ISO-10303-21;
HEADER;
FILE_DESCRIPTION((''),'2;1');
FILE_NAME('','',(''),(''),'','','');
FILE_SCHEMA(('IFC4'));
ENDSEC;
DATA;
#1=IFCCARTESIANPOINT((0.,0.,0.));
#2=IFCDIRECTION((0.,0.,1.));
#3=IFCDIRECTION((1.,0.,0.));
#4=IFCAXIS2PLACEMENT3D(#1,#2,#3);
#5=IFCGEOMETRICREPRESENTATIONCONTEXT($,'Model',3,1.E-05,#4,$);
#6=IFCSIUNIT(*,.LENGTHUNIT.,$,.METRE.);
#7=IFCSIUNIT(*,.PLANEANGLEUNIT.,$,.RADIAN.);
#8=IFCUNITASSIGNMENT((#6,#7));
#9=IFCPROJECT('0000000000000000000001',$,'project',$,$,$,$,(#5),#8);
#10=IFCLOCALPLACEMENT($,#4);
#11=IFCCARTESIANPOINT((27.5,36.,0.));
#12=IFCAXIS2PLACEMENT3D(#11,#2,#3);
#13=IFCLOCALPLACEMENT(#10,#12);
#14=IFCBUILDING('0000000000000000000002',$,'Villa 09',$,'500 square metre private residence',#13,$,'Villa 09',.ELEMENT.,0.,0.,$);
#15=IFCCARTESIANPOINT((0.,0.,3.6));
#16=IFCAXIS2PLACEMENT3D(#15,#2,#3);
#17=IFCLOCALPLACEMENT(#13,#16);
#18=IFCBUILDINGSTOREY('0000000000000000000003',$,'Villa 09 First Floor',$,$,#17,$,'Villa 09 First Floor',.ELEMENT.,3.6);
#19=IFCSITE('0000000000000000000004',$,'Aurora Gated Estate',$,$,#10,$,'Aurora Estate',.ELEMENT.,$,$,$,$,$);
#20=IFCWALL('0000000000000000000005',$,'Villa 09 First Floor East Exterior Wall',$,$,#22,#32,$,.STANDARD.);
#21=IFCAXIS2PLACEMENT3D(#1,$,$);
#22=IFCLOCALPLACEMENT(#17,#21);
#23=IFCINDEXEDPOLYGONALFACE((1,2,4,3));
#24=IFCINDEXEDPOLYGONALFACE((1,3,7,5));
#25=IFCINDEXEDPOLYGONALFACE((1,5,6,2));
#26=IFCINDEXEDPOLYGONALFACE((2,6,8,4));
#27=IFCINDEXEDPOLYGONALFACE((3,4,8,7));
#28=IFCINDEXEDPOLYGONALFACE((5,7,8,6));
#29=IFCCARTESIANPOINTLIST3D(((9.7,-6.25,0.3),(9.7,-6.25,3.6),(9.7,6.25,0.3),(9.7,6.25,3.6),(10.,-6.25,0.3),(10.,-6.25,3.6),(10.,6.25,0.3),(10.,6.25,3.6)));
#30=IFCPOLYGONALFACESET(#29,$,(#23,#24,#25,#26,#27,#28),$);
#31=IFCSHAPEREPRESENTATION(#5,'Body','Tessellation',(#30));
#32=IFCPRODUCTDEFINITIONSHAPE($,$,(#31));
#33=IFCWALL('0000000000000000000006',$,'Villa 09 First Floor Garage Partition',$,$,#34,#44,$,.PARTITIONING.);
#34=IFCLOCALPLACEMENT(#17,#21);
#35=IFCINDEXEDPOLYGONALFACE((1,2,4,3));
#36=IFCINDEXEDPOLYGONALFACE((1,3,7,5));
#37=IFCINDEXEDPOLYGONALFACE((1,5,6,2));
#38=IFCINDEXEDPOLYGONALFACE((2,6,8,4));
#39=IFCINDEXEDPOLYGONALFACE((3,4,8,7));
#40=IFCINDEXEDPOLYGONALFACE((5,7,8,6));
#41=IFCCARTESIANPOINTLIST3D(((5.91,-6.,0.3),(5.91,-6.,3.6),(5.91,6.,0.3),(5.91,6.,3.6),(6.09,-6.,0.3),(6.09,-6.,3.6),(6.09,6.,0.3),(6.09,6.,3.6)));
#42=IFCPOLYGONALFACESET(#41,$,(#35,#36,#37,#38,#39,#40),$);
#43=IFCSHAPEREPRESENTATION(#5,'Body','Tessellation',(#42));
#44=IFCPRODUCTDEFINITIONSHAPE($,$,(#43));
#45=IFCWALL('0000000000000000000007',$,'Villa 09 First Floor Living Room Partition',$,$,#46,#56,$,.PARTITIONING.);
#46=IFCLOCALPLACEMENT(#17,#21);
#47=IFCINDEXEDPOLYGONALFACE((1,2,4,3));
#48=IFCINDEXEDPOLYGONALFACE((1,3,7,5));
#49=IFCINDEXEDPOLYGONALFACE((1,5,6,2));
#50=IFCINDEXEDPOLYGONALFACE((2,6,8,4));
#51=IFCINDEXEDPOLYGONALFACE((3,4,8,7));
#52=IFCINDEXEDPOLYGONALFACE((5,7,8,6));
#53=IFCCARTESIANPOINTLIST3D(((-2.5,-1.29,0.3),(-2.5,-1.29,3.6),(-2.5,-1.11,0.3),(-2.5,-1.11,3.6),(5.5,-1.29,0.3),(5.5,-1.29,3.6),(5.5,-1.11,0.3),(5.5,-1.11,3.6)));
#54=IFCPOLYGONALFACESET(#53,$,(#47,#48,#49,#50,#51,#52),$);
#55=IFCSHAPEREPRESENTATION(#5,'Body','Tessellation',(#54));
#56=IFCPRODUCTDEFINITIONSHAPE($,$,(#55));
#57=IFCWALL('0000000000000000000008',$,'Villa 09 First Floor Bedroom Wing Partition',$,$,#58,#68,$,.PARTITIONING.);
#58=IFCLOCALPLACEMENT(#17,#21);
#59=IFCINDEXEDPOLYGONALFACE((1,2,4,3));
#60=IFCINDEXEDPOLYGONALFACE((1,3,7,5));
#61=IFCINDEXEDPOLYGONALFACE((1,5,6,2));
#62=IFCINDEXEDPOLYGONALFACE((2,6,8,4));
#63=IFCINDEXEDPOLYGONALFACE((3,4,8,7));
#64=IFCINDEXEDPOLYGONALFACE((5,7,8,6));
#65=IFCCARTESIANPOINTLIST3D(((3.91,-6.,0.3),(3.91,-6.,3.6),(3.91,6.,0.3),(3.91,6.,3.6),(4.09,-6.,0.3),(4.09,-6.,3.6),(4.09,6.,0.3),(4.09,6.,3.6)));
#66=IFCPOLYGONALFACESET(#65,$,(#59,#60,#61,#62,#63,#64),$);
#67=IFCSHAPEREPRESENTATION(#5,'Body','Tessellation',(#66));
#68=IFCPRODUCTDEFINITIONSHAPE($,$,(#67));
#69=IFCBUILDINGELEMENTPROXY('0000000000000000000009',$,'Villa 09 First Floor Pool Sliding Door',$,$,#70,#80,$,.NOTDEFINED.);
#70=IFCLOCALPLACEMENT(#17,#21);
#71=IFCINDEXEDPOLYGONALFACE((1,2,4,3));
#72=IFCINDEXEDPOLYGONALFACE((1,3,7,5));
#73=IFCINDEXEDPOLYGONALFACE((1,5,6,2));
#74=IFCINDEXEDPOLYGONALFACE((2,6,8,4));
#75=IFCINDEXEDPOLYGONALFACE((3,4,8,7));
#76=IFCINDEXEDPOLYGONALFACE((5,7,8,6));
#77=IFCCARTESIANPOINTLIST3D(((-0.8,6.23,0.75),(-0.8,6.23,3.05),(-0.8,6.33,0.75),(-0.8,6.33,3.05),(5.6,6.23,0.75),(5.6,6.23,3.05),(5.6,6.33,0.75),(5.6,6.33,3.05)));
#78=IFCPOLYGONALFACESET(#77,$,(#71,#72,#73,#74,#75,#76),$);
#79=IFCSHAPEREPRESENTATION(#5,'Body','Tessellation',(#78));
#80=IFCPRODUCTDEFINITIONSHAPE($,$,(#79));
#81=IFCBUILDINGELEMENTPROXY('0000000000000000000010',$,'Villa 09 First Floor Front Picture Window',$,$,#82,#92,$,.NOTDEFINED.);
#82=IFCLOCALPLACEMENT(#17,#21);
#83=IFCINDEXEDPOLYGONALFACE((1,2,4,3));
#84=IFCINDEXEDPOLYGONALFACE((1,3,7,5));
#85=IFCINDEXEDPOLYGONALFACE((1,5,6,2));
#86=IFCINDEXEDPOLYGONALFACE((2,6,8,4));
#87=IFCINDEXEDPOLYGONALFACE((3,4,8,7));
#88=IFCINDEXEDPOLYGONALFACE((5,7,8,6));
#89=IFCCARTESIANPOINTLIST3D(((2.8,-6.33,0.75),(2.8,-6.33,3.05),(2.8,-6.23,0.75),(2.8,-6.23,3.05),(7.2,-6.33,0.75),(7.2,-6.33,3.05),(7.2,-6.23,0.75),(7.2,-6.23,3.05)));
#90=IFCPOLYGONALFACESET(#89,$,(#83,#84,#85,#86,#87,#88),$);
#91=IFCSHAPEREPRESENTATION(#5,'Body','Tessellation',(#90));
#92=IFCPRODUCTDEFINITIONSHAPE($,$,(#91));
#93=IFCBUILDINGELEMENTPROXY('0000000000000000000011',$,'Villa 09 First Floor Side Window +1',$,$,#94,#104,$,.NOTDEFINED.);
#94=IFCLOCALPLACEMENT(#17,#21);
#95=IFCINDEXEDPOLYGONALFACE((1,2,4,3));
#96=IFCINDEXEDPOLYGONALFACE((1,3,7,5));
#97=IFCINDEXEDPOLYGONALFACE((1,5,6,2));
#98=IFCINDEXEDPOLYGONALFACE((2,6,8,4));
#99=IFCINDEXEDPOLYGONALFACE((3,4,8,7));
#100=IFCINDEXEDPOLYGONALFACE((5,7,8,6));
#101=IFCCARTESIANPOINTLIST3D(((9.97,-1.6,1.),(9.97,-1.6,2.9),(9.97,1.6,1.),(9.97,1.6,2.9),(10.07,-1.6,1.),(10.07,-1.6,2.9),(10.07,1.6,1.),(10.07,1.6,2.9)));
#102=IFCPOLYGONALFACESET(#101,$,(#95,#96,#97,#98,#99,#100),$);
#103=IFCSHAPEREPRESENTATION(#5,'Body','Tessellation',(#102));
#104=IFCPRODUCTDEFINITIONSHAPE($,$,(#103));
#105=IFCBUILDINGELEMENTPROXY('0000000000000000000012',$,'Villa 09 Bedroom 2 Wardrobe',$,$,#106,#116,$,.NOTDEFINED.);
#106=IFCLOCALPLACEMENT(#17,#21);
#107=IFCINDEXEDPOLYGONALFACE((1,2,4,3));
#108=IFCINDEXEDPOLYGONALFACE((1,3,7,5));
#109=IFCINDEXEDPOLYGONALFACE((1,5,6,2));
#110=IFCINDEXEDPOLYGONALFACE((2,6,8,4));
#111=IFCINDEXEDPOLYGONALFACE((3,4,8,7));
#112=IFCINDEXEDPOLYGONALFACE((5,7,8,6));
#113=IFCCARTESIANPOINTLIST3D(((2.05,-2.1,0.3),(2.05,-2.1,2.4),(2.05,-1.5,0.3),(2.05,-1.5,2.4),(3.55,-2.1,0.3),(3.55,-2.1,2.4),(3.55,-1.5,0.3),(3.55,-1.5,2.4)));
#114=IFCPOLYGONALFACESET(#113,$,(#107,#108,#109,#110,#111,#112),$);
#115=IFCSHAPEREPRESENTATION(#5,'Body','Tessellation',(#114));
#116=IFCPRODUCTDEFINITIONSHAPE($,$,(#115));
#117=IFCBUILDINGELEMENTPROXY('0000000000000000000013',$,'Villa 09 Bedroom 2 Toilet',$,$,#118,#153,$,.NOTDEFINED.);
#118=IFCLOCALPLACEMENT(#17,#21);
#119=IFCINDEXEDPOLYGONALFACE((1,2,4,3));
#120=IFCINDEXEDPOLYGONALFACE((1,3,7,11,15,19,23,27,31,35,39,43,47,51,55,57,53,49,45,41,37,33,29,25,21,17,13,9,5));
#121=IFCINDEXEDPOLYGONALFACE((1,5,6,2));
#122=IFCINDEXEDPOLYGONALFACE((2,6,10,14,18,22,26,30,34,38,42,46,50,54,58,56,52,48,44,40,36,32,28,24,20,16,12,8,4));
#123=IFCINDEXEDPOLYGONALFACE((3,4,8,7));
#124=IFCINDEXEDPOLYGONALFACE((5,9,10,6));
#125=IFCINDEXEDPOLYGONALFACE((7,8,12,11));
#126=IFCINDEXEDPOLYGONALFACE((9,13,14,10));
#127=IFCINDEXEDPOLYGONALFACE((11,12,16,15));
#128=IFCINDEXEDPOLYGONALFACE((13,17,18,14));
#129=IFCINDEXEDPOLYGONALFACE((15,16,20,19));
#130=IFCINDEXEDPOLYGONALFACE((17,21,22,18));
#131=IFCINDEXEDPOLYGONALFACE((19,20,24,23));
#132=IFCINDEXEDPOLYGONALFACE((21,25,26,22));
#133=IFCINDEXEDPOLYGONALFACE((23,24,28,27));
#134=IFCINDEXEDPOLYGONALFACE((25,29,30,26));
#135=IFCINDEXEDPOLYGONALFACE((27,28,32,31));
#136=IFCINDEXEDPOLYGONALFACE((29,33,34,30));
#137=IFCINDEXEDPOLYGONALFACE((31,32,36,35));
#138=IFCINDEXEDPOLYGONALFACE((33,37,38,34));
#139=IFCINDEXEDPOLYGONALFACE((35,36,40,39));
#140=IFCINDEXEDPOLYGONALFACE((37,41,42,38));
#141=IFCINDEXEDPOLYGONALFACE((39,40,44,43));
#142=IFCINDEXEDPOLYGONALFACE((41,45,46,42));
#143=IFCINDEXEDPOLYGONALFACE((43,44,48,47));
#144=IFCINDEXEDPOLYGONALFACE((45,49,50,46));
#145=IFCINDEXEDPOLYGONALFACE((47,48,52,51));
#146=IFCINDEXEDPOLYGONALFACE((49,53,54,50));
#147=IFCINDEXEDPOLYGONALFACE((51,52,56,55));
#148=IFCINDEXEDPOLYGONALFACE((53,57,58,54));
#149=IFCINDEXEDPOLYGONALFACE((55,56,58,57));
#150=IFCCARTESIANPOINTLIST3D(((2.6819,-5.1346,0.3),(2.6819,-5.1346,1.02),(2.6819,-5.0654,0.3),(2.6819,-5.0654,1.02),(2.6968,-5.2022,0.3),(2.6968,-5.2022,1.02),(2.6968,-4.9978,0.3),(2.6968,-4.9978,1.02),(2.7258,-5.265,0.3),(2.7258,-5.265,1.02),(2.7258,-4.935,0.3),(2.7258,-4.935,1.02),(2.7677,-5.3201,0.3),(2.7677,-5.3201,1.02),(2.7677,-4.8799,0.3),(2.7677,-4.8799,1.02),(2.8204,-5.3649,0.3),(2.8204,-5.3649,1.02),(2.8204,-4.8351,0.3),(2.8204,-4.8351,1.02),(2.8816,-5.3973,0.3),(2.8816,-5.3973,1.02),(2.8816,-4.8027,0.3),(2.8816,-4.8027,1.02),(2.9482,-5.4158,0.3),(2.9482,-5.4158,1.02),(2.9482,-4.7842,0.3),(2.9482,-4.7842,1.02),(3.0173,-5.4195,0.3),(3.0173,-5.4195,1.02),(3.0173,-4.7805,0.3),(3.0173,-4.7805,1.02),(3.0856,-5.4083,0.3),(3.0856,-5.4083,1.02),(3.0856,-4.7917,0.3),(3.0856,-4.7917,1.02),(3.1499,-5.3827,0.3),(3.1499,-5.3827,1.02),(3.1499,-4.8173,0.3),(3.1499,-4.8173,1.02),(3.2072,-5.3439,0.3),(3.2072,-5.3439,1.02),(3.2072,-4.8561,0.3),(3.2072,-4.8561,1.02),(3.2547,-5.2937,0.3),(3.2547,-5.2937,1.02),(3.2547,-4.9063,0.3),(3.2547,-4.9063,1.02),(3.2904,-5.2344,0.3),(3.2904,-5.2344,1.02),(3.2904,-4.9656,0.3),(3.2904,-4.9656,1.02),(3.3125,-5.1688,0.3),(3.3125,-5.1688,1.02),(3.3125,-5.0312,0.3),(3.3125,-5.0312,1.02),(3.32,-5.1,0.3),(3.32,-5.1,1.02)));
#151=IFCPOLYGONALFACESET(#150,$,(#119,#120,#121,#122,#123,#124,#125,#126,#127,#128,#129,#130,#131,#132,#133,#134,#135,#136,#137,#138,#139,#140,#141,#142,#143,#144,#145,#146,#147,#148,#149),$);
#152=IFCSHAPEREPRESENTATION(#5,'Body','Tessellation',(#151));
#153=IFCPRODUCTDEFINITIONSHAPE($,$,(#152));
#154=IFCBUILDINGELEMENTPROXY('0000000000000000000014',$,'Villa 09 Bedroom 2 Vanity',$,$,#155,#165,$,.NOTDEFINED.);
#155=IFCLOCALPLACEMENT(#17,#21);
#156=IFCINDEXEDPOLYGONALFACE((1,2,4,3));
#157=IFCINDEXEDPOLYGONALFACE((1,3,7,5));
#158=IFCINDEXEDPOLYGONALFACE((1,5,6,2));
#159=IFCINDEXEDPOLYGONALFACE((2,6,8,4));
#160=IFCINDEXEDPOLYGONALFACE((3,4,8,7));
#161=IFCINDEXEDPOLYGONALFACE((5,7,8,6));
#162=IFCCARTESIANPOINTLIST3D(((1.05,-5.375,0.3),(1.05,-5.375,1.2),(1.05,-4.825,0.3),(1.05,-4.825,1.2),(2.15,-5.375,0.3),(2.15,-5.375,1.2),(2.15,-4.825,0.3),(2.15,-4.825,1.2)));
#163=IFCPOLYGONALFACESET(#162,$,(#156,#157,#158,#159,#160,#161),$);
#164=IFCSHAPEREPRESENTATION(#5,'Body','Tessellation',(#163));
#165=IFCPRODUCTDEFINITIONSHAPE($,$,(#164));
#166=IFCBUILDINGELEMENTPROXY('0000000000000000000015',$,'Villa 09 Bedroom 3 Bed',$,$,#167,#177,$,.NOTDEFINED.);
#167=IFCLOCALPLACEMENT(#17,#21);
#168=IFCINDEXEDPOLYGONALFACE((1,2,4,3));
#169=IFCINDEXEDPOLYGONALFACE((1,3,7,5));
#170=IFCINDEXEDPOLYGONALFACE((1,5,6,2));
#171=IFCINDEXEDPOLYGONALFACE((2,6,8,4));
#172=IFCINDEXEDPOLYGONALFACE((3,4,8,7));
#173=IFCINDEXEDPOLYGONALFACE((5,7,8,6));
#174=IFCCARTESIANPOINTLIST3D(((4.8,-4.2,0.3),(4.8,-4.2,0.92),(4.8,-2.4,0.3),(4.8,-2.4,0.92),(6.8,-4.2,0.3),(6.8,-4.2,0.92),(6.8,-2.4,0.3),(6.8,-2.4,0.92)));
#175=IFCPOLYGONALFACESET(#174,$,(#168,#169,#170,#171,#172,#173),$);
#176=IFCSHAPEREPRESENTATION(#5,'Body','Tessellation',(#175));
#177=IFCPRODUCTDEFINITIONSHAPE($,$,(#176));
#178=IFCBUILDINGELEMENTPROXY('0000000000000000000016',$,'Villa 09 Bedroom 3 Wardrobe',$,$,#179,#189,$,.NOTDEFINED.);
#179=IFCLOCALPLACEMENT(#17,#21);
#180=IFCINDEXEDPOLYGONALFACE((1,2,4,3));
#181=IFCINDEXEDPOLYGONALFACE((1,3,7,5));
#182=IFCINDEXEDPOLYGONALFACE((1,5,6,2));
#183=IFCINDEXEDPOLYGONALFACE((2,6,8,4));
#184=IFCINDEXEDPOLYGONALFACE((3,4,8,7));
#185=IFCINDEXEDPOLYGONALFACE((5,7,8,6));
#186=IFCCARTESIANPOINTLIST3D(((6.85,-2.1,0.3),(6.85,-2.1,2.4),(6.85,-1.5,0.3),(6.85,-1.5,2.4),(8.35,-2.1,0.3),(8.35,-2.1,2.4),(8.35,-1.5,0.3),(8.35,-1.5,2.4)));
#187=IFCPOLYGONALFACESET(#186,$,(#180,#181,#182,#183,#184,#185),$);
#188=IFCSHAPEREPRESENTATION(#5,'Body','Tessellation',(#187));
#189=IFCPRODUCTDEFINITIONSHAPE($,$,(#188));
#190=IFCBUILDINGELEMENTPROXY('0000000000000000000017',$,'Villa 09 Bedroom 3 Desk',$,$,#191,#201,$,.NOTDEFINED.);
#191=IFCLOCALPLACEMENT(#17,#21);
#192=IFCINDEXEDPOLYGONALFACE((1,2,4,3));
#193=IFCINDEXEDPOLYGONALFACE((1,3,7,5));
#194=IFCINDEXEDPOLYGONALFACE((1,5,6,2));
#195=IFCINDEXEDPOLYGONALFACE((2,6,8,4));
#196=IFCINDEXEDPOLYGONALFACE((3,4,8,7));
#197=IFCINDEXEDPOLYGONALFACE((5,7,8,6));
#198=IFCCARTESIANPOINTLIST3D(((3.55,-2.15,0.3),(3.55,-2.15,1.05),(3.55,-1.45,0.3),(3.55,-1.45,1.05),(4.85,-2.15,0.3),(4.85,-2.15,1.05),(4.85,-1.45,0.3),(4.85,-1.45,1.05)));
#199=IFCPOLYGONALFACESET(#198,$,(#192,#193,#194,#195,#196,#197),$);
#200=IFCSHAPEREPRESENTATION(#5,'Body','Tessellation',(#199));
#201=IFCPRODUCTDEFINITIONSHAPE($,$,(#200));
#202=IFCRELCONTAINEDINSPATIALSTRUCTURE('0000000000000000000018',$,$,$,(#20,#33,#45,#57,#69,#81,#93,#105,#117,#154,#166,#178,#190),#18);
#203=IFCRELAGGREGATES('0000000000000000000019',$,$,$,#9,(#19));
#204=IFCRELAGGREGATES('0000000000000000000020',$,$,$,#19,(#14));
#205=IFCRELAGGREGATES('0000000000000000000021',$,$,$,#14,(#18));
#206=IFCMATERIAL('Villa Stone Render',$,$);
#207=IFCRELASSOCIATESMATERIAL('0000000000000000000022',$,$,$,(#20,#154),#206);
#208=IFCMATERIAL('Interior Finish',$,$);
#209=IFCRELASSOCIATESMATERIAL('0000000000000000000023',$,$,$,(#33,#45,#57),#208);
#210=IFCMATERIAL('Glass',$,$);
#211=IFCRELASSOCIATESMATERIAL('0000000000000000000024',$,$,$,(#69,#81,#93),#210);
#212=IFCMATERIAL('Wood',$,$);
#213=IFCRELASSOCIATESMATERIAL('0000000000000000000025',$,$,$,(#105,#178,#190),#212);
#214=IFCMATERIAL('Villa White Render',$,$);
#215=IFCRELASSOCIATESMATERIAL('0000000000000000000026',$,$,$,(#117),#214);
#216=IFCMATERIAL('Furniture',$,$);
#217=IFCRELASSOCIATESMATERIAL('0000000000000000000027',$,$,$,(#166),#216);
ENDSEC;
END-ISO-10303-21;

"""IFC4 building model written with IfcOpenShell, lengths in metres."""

from ifc_helpers import new_model, si_unit, frame, origin_with_axes, origin_2d_with_axis, place, context, project, spatial, rectangle, circle, extrude, material, element, save


model = new_model("IFC4")

# Units and contexts
model_context = context("Model", 3, precision=1e-05, world=origin_with_axes())
ifc_project = project(units=[si_unit("LENGTHUNIT", "METRE"), si_unit("PLANEANGLEUNIT", "RADIAN")], contexts=[model_context])

# Site, building, storey
site_placement = place(None, origin_with_axes())
site = spatial("IfcSite", under=ifc_project, at=site_placement, Name="Aurora Gated Estate", LongName="Aurora Estate", CompositionType="ELEMENT")
building_placement = place(site_placement, frame((27.5, 36.0, 0.0), z_axis=(0.0, 0.0, 1.0), x_axis=(1.0, 0.0, 0.0)))
building = spatial("IfcBuilding", under=site, at=building_placement, Name="Villa 09", ObjectType="500 square metre private residence", LongName="Villa 09", CompositionType="ELEMENT", ElevationOfRefHeight=0.0, ElevationOfTerrain=0.0)
storey_placement = place(building_placement, frame((0.0, 0.0, 3.6), z_axis=(0.0, 0.0, 1.0), x_axis=(1.0, 0.0, 0.0)))
storey = spatial("IfcBuildingStorey", under=building, at=storey_placement, Name="Villa 09 First Floor", LongName="Villa 09 First Floor", CompositionType="ELEMENT", Elevation=3.6)

# Walls
ifc_material_1 = material(Name="Villa Stone Render")
wall_1_placement = place(storey_placement, frame((9.85, 0.0, 0.3), z_axis=(0.0, 0.0, 1.0), x_axis=(1.0, 0.0, 0.0)))
element("IfcWall", 1, at=wall_1_placement, inside=storey, material=ifc_material_1, Name="Villa 09 First Floor East Exterior Wall", PredefinedType="STANDARD", context=model_context, shape_type="SweptSolid", body=[
    extrude(rectangle(XDim=0.3, YDim=12.5, at=origin_2d_with_axis()), origin_with_axes(), (0.0, 0.0, 1.0), 3.3),
])
ifc_material_2 = material(Name="Interior Finish")
wall_2_placement = place(storey_placement, frame((6.0, 0.0, 0.3), z_axis=(0.0, 0.0, 1.0), x_axis=(1.0, 0.0, 0.0)))
element("IfcWall", 2, at=wall_2_placement, inside=storey, material=ifc_material_2, Name="Villa 09 First Floor Garage Partition", PredefinedType="PARTITIONING", context=model_context, shape_type="SweptSolid", body=[
    extrude(rectangle(XDim=0.18, YDim=12.0, at=origin_2d_with_axis()), origin_with_axes(), (0.0, 0.0, 1.0), 3.3),
])
wall_3_placement = place(storey_placement, frame((1.5, -1.2, 0.3), z_axis=(0.0, 0.0, 1.0), x_axis=(1.0, 0.0, 0.0)))
element("IfcWall", 3, at=wall_3_placement, inside=storey, material=ifc_material_2, Name="Villa 09 First Floor Living Room Partition", PredefinedType="PARTITIONING", context=model_context, shape_type="SweptSolid", body=[
    extrude(rectangle(XDim=8.0, YDim=0.18, at=origin_2d_with_axis()), origin_with_axes(), (0.0, 0.0, 1.0), 3.3),
])
wall_4_placement = place(storey_placement, frame((4.0, 0.0, 0.3), z_axis=(0.0, 0.0, 1.0), x_axis=(1.0, 0.0, 0.0)))
element("IfcWall", 4, at=wall_4_placement, inside=storey, material=ifc_material_2, Name="Villa 09 First Floor Bedroom Wing Partition", PredefinedType="PARTITIONING", context=model_context, shape_type="SweptSolid", body=[
    extrude(rectangle(XDim=0.18, YDim=12.0, at=origin_2d_with_axis()), origin_with_axes(), (0.0, 0.0, 1.0), 3.3),
])

# Building element proxies
ifc_material_3 = material(Name="Glass")
proxy_1_placement = place(storey_placement, frame((2.4, 6.28, 0.75), z_axis=(0.0, 0.0, 1.0), x_axis=(1.0, 0.0, 0.0)))
element("IfcBuildingElementProxy", 5, at=proxy_1_placement, inside=storey, material=ifc_material_3, Name="Villa 09 First Floor Pool Sliding Door", PredefinedType="NOTDEFINED", context=model_context, shape_type="SweptSolid", body=[
    extrude(rectangle(XDim=6.4, YDim=0.1, at=origin_2d_with_axis()), origin_with_axes(), (0.0, 0.0, 1.0), 2.3),
])
proxy_2_placement = place(storey_placement, frame((5.0, -6.28, 0.75), z_axis=(0.0, 0.0, 1.0), x_axis=(1.0, 0.0, 0.0)))
element("IfcBuildingElementProxy", 6, at=proxy_2_placement, inside=storey, material=ifc_material_3, Name="Villa 09 First Floor Front Picture Window", PredefinedType="NOTDEFINED", context=model_context, shape_type="SweptSolid", body=[
    extrude(rectangle(XDim=4.4, YDim=0.1, at=origin_2d_with_axis()), origin_with_axes(), (0.0, 0.0, 1.0), 2.3),
])
proxy_3_placement = place(storey_placement, frame((10.02, 0.0, 1.0), z_axis=(0.0, 0.0, 1.0), x_axis=(0.0, 1.0, 0.0)))
element("IfcBuildingElementProxy", 7, at=proxy_3_placement, inside=storey, material=ifc_material_3, Name="Villa 09 First Floor Side Window +1", PredefinedType="NOTDEFINED", context=model_context, shape_type="SweptSolid", body=[
    extrude(rectangle(XDim=3.2, YDim=0.1, at=origin_2d_with_axis()), origin_with_axes(), (0.0, 0.0, 1.0), 1.9),
])
ifc_material_4 = material(Name="Wood")
proxy_4_placement = place(storey_placement, frame((2.8, -1.8, 0.3), z_axis=(0.0, 0.0, 1.0), x_axis=(1.0, 0.0, 0.0)))
element("IfcBuildingElementProxy", 8, at=proxy_4_placement, inside=storey, material=ifc_material_4, Name="Villa 09 Bedroom 2 Wardrobe", PredefinedType="NOTDEFINED", context=model_context, shape_type="SweptSolid", body=[
    extrude(rectangle(XDim=1.5, YDim=0.6, at=origin_2d_with_axis()), origin_with_axes(), (0.0, 0.0, 1.0), 2.1),
])
ifc_material_5 = material(Name="Villa White Render")
proxy_5_placement = place(storey_placement, frame((3.0, -5.1, 0.3), z_axis=(0.0, 0.0, 1.0), x_axis=(1.0, 0.0, 0.0)))
element("IfcBuildingElementProxy", 9, at=proxy_5_placement, inside=storey, material=ifc_material_5, Name="Villa 09 Bedroom 2 Toilet", PredefinedType="NOTDEFINED", context=model_context, shape_type="SweptSolid", body=[
    extrude(circle(Radius=0.32, at=origin_2d_with_axis()), origin_with_axes(), (0.0, 0.0, 1.0), 0.72),
])
proxy_6_placement = place(storey_placement, frame((1.6, -5.1, 0.3), z_axis=(0.0, 0.0, 1.0), x_axis=(1.0, 0.0, 0.0)))
element("IfcBuildingElementProxy", 10, at=proxy_6_placement, inside=storey, material=ifc_material_1, Name="Villa 09 Bedroom 2 Vanity", PredefinedType="NOTDEFINED", context=model_context, shape_type="SweptSolid", body=[
    extrude(rectangle(XDim=1.1, YDim=0.55, at=origin_2d_with_axis()), origin_with_axes(), (0.0, 0.0, 1.0), 0.9),
])
ifc_material_6 = material(Name="Furniture")
proxy_7_placement = place(storey_placement, frame((5.8, -3.3, 0.3), z_axis=(0.0, 0.0, 1.0), x_axis=(1.0, 0.0, 0.0)))
element("IfcBuildingElementProxy", 11, at=proxy_7_placement, inside=storey, material=ifc_material_6, Name="Villa 09 Bedroom 3 Bed", PredefinedType="NOTDEFINED", context=model_context, shape_type="SweptSolid", body=[
    extrude(rectangle(XDim=2.0, YDim=1.8, at=origin_2d_with_axis()), origin_with_axes(), (0.0, 0.0, 1.0), 0.62),
])
proxy_8_placement = place(storey_placement, frame((7.6, -1.8, 0.3), z_axis=(0.0, 0.0, 1.0), x_axis=(1.0, 0.0, 0.0)))
element("IfcBuildingElementProxy", 12, at=proxy_8_placement, inside=storey, material=ifc_material_4, Name="Villa 09 Bedroom 3 Wardrobe", PredefinedType="NOTDEFINED", context=model_context, shape_type="SweptSolid", body=[
    extrude(rectangle(XDim=1.5, YDim=0.6, at=origin_2d_with_axis()), origin_with_axes(), (0.0, 0.0, 1.0), 2.1),
])
proxy_9_placement = place(storey_placement, frame((4.2, -1.8, 0.3), z_axis=(0.0, 0.0, 1.0), x_axis=(1.0, 0.0, 0.0)))
element("IfcBuildingElementProxy", 13, at=proxy_9_placement, inside=storey, material=ifc_material_4, Name="Villa 09 Bedroom 3 Desk", PredefinedType="NOTDEFINED", context=model_context, shape_type="SweptSolid", body=[
    extrude(rectangle(XDim=1.3, YDim=0.7, at=origin_2d_with_axis()), origin_with_axes(), (0.0, 0.0, 1.0), 0.75),
])

save(model, "model.ifc")
